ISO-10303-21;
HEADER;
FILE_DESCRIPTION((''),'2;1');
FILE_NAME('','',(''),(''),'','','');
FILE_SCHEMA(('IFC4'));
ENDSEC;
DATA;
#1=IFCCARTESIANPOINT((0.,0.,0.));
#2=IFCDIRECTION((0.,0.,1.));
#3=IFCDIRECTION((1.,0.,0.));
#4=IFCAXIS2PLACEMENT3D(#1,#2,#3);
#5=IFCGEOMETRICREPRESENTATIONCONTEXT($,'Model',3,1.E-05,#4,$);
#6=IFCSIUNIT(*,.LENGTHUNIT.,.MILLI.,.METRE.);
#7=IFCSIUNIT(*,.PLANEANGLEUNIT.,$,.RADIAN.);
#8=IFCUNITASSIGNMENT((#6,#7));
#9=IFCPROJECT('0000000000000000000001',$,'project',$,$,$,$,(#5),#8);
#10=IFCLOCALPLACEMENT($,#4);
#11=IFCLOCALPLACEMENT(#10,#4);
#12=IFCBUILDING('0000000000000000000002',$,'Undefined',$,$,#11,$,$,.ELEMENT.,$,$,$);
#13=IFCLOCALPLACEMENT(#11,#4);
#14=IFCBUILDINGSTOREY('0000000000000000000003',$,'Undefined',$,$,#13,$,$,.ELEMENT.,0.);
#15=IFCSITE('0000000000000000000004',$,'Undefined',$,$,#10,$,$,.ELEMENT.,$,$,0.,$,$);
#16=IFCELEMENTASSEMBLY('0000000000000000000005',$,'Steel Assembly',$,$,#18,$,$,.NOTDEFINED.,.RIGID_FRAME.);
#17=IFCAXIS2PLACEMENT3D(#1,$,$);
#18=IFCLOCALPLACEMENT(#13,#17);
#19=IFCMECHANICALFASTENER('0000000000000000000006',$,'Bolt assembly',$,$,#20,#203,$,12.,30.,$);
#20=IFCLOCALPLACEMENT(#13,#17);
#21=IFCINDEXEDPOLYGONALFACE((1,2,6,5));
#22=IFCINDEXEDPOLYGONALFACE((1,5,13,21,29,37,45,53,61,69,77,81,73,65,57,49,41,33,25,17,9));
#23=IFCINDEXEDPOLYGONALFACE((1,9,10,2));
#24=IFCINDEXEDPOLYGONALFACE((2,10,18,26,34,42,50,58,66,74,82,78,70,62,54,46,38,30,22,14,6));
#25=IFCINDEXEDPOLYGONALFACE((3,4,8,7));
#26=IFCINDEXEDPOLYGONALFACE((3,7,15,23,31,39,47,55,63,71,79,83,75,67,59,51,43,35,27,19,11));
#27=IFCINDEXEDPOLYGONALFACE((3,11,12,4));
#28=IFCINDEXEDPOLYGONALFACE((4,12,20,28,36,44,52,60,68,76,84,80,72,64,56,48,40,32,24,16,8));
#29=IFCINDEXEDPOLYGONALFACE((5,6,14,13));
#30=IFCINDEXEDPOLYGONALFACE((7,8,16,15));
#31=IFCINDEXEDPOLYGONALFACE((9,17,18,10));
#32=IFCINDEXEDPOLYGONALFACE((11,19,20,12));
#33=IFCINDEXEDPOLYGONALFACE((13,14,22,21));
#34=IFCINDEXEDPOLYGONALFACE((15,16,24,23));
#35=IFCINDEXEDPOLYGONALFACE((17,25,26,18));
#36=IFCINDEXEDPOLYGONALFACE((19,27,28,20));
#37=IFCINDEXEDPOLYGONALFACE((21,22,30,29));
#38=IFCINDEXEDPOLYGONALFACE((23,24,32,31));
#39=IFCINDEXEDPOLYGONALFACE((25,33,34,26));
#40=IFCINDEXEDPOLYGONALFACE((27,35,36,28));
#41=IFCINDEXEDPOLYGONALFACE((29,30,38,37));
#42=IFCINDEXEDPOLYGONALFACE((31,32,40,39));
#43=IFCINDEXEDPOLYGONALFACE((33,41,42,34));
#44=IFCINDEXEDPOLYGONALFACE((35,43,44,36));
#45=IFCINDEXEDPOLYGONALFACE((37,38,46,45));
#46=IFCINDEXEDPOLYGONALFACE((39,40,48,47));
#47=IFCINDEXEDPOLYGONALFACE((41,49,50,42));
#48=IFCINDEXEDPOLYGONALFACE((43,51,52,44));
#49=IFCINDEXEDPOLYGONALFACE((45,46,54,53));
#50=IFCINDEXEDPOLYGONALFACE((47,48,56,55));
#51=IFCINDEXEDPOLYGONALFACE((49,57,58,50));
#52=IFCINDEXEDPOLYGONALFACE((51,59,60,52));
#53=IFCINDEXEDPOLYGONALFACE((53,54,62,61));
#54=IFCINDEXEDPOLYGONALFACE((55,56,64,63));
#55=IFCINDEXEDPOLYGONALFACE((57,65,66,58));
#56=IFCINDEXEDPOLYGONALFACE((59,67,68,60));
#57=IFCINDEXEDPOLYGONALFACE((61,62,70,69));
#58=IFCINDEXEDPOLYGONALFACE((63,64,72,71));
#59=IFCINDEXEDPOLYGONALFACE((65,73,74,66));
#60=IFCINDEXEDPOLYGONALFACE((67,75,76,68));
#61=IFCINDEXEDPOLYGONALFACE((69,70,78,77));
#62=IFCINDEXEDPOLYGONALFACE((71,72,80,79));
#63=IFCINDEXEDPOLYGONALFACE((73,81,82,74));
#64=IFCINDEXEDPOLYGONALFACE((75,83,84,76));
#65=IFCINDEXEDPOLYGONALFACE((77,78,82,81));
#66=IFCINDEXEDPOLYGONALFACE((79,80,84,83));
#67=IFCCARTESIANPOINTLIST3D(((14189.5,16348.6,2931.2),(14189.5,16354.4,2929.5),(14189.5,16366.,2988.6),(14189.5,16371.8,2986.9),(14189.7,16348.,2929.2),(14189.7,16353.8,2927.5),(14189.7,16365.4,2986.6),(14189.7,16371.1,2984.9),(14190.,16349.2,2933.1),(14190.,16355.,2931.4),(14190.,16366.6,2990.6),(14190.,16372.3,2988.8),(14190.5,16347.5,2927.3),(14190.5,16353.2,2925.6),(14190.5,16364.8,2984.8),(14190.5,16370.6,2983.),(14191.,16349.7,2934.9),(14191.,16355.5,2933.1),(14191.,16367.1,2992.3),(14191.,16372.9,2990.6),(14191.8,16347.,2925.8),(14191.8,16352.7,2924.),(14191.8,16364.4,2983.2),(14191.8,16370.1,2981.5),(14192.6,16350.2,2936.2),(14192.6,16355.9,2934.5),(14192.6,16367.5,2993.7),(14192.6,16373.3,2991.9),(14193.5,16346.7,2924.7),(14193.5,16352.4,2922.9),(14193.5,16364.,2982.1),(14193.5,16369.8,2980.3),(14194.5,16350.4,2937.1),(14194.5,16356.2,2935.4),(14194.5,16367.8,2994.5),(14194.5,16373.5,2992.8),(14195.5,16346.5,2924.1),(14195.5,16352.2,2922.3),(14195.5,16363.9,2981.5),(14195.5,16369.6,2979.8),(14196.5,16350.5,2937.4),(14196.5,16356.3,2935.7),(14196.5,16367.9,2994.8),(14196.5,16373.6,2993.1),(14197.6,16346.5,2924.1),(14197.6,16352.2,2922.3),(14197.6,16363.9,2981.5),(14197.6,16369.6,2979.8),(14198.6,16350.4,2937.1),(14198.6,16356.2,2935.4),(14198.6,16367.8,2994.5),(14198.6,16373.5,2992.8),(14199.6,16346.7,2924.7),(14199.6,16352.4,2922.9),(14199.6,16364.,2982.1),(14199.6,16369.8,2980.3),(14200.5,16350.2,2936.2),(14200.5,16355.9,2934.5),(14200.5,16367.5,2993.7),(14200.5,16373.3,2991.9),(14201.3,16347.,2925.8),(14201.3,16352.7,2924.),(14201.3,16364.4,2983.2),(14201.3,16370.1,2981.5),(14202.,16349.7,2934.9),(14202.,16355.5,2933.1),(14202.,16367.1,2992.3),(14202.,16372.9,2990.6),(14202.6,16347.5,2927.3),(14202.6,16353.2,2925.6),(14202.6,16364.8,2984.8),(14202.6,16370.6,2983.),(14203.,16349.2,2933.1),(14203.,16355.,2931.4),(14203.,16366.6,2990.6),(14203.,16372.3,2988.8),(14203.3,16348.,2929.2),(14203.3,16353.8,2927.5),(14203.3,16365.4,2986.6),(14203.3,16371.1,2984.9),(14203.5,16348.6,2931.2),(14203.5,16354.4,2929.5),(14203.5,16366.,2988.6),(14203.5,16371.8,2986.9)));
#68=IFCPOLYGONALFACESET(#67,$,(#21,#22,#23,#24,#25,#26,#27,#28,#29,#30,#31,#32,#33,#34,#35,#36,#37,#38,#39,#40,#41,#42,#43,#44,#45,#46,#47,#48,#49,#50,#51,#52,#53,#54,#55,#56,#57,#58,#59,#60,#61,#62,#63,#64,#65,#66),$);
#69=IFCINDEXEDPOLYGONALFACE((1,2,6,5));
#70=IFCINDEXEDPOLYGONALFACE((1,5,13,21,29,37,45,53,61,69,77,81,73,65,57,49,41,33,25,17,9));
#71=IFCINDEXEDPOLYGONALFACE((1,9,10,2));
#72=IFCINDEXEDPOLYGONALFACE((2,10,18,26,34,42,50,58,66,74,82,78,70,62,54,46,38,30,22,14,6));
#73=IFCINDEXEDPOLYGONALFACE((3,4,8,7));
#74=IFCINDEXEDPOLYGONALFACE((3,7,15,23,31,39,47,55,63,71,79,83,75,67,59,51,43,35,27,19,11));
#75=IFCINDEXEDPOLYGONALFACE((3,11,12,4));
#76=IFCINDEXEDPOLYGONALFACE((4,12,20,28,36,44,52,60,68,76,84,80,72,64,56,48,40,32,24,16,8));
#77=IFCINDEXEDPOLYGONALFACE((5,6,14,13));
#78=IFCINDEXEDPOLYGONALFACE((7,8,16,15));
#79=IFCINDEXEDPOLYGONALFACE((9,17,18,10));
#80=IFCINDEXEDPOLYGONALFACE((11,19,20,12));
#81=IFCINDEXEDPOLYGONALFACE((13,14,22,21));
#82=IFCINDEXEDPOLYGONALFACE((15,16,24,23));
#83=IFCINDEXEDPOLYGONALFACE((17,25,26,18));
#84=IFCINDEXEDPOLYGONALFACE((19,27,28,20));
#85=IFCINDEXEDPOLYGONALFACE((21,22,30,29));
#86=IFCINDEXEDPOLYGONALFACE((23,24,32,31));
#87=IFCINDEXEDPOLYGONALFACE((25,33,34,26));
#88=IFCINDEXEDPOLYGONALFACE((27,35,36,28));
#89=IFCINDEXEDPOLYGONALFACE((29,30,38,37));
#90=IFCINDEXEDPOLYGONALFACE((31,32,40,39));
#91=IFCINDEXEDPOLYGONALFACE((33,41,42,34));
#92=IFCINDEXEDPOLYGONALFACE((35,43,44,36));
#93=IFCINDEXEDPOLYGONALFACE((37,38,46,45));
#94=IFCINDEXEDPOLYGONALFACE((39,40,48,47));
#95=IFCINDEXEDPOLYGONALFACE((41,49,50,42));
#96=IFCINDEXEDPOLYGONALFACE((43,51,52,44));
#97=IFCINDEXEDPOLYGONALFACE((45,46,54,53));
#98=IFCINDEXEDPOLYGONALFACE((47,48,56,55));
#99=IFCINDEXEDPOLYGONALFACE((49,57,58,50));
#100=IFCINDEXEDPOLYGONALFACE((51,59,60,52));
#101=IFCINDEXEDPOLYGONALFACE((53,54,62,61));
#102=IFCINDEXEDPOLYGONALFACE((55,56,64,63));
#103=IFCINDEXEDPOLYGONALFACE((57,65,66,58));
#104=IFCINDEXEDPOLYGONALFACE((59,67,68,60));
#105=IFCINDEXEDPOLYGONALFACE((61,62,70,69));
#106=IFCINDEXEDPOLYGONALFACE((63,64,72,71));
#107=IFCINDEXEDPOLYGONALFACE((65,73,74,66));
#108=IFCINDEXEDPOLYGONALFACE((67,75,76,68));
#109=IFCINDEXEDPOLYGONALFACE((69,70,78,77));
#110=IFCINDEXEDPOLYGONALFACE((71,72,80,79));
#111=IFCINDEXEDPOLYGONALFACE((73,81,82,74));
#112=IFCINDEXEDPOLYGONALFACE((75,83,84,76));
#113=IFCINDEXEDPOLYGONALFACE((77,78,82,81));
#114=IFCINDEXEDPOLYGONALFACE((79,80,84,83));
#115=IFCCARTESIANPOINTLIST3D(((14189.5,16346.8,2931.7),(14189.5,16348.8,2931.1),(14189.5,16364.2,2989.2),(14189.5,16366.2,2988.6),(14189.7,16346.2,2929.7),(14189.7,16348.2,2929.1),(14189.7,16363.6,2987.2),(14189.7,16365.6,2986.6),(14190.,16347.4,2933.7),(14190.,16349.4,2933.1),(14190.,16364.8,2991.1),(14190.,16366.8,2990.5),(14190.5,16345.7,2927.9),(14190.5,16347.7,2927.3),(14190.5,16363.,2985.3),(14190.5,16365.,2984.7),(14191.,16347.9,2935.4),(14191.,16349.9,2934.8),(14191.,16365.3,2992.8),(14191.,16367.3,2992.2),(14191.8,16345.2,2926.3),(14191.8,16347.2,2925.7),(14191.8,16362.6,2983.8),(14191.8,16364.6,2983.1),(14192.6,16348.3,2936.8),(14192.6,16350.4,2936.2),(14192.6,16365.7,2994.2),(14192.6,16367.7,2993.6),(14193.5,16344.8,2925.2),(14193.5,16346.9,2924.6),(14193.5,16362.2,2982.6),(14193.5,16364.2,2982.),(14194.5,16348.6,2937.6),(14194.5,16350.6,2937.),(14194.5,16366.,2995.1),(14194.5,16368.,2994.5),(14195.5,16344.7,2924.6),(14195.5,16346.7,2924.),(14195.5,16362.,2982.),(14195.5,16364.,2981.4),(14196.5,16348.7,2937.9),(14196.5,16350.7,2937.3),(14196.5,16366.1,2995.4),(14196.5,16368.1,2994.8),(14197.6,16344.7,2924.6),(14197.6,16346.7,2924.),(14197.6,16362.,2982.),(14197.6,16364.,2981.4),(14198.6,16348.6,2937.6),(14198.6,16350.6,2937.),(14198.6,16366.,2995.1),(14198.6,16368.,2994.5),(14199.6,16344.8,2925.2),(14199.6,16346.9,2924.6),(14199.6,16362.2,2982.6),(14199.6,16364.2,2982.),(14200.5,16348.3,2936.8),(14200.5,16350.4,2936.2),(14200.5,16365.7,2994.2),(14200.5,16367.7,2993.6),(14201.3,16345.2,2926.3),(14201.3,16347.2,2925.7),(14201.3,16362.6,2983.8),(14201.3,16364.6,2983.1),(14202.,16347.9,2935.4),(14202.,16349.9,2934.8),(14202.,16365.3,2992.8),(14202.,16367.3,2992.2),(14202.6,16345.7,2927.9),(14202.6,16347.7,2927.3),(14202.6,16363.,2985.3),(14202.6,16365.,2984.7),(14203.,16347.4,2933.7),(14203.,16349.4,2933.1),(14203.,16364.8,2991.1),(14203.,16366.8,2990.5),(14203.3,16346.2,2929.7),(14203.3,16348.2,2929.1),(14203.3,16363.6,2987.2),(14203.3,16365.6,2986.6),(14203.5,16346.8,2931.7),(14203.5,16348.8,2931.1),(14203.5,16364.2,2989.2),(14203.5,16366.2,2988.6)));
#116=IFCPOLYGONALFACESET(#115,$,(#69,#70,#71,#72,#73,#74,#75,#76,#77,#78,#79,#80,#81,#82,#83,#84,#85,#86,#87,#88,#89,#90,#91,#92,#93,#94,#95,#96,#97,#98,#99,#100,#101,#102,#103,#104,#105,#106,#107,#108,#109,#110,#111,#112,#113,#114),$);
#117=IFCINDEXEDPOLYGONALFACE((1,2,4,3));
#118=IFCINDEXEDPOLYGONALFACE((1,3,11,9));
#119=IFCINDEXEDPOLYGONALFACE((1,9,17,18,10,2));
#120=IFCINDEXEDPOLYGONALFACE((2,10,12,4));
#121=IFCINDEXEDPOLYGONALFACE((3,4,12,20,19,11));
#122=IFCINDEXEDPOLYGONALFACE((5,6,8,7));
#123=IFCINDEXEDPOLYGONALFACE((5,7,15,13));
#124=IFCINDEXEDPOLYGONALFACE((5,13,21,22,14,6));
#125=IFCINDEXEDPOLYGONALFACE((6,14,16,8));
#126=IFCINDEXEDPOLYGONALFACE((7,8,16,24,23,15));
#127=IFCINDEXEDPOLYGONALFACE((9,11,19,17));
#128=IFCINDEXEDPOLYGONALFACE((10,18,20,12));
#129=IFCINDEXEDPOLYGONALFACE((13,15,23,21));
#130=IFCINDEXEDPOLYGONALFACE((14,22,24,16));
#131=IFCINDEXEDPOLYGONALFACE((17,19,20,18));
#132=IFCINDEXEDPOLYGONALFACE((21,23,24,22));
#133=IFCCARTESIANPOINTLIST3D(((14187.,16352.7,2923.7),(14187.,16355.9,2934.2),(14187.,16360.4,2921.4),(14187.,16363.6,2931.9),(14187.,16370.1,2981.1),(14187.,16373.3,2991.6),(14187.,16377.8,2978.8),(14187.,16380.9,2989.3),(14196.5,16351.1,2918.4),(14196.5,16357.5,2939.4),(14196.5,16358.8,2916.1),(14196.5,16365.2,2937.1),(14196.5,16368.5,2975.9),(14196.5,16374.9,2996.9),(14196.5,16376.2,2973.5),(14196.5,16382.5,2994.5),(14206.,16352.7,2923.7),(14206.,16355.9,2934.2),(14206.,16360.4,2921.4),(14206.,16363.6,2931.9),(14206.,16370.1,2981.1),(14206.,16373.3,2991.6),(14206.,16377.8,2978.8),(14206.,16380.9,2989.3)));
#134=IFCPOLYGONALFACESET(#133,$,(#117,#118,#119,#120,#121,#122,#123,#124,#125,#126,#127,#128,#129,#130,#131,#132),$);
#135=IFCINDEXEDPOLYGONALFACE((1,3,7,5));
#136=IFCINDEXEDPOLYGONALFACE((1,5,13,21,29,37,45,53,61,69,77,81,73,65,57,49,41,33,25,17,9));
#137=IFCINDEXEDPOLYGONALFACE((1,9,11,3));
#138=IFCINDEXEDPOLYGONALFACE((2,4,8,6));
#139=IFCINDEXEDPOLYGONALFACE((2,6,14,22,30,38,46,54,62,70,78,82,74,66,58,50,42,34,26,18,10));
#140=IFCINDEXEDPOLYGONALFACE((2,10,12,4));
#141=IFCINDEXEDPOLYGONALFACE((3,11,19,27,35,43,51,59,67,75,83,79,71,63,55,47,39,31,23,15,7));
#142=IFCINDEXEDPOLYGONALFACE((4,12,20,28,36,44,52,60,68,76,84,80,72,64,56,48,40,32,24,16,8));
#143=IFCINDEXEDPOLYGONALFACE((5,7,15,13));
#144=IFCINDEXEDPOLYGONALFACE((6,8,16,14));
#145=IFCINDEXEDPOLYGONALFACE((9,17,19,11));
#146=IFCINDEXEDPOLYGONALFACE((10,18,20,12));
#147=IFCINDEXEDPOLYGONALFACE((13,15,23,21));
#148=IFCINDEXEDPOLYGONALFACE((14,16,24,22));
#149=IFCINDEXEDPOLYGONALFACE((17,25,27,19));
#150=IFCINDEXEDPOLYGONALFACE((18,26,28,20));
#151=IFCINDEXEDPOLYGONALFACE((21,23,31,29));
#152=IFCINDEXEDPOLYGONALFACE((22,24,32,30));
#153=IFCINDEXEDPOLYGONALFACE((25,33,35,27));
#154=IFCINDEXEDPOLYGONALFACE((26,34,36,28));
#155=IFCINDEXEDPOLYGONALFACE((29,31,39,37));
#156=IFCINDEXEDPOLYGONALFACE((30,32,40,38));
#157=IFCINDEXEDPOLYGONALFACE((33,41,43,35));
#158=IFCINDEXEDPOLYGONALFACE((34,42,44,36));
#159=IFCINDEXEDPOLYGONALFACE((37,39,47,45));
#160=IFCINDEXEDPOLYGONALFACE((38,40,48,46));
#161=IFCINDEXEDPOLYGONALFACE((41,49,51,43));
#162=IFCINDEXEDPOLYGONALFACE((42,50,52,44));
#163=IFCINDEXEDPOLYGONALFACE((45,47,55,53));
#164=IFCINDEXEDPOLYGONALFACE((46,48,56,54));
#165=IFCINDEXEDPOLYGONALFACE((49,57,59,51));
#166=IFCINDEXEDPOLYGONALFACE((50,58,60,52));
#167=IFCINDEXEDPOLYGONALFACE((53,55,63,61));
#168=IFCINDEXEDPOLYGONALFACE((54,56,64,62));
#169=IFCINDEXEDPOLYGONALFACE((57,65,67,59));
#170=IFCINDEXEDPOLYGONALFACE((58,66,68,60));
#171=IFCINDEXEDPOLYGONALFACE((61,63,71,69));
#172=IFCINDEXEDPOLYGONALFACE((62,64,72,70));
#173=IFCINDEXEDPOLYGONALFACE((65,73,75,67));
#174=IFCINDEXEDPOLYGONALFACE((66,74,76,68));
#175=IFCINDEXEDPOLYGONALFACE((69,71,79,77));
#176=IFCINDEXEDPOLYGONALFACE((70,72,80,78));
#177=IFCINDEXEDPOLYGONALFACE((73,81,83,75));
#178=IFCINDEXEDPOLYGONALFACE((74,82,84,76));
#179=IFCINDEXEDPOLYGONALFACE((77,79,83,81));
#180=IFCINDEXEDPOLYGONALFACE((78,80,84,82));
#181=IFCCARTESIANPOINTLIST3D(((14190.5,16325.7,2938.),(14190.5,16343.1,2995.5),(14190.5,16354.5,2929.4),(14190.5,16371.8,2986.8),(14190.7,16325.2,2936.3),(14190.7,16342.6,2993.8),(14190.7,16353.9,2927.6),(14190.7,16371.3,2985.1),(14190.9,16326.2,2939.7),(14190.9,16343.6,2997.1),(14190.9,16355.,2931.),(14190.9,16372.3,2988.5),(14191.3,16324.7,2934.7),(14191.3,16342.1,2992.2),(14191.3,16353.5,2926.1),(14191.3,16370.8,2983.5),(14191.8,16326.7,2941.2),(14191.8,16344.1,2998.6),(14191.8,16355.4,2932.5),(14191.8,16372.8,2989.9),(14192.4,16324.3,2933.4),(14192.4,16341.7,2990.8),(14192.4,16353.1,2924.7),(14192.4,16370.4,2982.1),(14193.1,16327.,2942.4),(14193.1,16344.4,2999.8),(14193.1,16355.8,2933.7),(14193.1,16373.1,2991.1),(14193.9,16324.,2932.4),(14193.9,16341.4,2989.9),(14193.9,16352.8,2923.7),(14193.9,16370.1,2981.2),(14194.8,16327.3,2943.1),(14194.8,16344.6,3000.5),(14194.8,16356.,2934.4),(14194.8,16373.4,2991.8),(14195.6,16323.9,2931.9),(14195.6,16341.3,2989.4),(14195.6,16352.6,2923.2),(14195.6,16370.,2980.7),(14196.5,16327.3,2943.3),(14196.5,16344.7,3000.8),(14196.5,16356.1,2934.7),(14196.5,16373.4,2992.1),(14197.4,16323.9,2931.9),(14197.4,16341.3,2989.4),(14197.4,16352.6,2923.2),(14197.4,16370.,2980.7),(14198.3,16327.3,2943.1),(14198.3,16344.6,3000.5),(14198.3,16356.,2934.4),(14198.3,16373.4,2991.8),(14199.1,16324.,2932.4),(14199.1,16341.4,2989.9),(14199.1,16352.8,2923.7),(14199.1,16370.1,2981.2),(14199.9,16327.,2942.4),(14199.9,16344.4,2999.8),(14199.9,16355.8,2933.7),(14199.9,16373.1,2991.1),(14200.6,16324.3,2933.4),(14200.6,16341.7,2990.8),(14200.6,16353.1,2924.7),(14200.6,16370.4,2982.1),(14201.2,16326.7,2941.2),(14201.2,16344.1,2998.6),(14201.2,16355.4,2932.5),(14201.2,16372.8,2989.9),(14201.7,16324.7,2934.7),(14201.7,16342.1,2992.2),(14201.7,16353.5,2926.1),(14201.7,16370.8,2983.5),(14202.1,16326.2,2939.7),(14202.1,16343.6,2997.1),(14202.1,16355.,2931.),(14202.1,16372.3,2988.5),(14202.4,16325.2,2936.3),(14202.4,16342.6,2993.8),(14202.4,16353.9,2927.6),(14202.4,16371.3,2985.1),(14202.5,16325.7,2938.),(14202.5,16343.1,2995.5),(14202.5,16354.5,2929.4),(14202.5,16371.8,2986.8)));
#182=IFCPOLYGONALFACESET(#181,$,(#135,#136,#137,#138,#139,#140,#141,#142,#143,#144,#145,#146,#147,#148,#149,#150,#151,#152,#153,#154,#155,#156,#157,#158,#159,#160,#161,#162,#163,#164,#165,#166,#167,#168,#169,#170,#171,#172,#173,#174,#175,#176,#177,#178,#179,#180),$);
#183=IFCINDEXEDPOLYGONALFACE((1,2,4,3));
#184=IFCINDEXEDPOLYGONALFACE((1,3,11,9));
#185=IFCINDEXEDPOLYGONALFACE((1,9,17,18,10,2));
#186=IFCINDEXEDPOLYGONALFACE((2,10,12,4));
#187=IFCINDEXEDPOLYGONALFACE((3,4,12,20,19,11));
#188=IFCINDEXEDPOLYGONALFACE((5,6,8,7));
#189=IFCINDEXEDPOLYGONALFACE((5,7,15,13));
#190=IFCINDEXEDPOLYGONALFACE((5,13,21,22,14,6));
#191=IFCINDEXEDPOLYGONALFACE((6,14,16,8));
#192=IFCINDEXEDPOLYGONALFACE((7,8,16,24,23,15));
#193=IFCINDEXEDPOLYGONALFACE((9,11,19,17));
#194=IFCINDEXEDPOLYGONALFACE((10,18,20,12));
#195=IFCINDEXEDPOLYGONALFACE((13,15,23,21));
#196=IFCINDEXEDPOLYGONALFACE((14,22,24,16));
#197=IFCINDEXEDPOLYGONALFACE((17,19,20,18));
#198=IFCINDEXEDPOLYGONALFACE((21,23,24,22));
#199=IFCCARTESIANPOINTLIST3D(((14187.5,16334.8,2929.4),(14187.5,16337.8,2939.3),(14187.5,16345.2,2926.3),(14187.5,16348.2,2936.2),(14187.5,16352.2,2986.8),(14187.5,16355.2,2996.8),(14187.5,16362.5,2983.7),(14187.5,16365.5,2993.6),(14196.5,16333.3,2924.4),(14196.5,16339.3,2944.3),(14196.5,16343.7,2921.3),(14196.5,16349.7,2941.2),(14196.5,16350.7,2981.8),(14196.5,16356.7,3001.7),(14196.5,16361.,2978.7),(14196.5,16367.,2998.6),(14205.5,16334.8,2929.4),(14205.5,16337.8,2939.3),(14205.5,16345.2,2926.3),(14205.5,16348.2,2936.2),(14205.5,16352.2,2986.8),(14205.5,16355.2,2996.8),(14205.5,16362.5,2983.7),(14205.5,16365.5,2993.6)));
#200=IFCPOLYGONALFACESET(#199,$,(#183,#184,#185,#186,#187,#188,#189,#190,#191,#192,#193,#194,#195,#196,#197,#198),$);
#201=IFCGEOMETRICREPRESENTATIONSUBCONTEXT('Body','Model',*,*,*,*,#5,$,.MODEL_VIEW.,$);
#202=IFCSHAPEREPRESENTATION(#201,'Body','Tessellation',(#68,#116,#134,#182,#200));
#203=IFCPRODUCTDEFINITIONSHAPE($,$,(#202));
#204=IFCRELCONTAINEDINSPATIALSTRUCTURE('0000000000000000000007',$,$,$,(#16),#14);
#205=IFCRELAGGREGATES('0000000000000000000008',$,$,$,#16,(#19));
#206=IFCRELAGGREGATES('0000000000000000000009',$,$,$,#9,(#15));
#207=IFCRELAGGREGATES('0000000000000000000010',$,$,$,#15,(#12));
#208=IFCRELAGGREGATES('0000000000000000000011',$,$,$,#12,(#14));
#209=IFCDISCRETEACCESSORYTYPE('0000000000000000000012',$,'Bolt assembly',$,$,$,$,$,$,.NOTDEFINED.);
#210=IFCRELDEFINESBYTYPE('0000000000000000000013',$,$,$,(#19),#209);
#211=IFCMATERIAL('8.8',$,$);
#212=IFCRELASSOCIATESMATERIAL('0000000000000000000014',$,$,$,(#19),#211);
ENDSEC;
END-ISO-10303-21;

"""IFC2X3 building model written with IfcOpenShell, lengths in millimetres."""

from ifc_helpers import new_model, si_unit, frame, origin_with_axes, origin_2d_with_axis, place, context, subcontext, project, spatial, polyline, circle, outline, extrude, source, transform, mapped, material, type_object, element, aggregate, save


model = new_model("IFC2X3")

# Units and contexts
model_context = context("Model", 3, precision=1e-05, world=origin_with_axes())
body_context = subcontext(model_context, "Body", "Model", "MODEL_VIEW")
ifc_project = project(units=[si_unit("LENGTHUNIT", "METRE", prefix="MILLI"), si_unit("PLANEANGLEUNIT", "RADIAN")], contexts=[model_context])

# Site, building, storey
site_placement = place(None, origin_with_axes())
site = spatial("IfcSite", under=ifc_project, at=site_placement, Name="Undefined", CompositionType="ELEMENT", RefElevation=0.0)
building_placement = place(site_placement, origin_with_axes())
building = spatial("IfcBuilding", under=site, at=building_placement, Name="Undefined", CompositionType="ELEMENT")
storey_placement = place(building_placement, origin_with_axes())
storey = spatial("IfcBuildingStorey", under=building, at=storey_placement, Name="Undefined", CompositionType="ELEMENT", Elevation=0.0)

# Shared definitions
discrete_accessory_type_1 = type_object("IfcDiscreteAccessoryType", Name="Bolt assembly")

# Element assembly, mechanical fastener
assembly_1_placement = place(storey_placement, origin_with_axes())
assembly_1 = element("IfcElementAssembly", 1, at=assembly_1_placement, inside=storey, Name="Steel Assembly", AssemblyPlace="NOTDEFINED", PredefinedType="RIGID_FRAME")
ifc_material_1 = material(Name="8.8")
shared_shape_1 = source(origin_with_axes(), body_context, "Body", "SweptSolid", [
    extrude(circle(Radius=7.0, at=origin_2d_with_axis()), frame((0.0, -2.9, 0.0), z_axis=(0.0, 1.0, 0.0), x_axis=(1.0, 0.0, 0.0)), (0.0, 0.0, 1.0), 6.0),
    extrude(circle(Radius=7.0, at=origin_2d_with_axis()), frame((0.0, 2.9, 0.0), z_axis=(0.0, 1.0, 0.0), x_axis=(1.0, 0.0, 0.0)), (0.0, 0.0, 1.0), 2.1),
    extrude(outline(polyline([(11.0, 0.0), (5.5, 9.5), (-5.5, 9.5), (-11.0, 0.0), (-5.5, -9.5), (5.5, -9.5), (11.0, 0.0)])), frame((0.0, -11.0, 0.0), z_axis=(0.0, 1.0, 0.0), x_axis=(1.0, 0.0, 0.0)), (0.0, 0.0, 1.0), 8.0),
    extrude(circle(Radius=6.0, at=origin_2d_with_axis()), frame((0.0, -3.0, 0.0), z_axis=(0.0, 1.0, 0.0), x_axis=(1.0, 0.0, 0.0)), (0.0, 0.0, 1.0), 30.0),
    extrude(outline(polyline([(10.4, 0.0), (5.2, 9.0), (-5.2, 9.0), (-10.4, 0.0), (-5.2, -9.0), (5.2, -9.0), (10.4, 0.0)])), frame((0.0, 5.0, 0.0), z_axis=(0.0, 1.0, 0.0), x_axis=(1.0, 0.0, 0.0)), (0.0, 0.0, 1.0), 10.8),
])
mechanical_fastener_1_placement = place(assembly_1_placement, frame((14151.5, 16338.4, 2886.7), z_axis=(1.0, 0.0, 0.0), x_axis=(0.0, 0.289497, 0.957179)))
mechanical_fastener_1 = element("IfcMechanicalFastener", 2, at=mechanical_fastener_1_placement, type_object=discrete_accessory_type_1, material=ifc_material_1, Name="Bolt assembly", NominalDiameter=12.0, NominalLength=30.0, context=body_context, shape_type="MappedRepresentation", body=[
    mapped(shared_shape_1, transform((45.0, 0.0, 45.0))),
    mapped(shared_shape_1, transform((105.0, 0.0, 45.0))),
])
aggregate(assembly_1, [mechanical_fastener_1])

save(model, "model.ifc")
